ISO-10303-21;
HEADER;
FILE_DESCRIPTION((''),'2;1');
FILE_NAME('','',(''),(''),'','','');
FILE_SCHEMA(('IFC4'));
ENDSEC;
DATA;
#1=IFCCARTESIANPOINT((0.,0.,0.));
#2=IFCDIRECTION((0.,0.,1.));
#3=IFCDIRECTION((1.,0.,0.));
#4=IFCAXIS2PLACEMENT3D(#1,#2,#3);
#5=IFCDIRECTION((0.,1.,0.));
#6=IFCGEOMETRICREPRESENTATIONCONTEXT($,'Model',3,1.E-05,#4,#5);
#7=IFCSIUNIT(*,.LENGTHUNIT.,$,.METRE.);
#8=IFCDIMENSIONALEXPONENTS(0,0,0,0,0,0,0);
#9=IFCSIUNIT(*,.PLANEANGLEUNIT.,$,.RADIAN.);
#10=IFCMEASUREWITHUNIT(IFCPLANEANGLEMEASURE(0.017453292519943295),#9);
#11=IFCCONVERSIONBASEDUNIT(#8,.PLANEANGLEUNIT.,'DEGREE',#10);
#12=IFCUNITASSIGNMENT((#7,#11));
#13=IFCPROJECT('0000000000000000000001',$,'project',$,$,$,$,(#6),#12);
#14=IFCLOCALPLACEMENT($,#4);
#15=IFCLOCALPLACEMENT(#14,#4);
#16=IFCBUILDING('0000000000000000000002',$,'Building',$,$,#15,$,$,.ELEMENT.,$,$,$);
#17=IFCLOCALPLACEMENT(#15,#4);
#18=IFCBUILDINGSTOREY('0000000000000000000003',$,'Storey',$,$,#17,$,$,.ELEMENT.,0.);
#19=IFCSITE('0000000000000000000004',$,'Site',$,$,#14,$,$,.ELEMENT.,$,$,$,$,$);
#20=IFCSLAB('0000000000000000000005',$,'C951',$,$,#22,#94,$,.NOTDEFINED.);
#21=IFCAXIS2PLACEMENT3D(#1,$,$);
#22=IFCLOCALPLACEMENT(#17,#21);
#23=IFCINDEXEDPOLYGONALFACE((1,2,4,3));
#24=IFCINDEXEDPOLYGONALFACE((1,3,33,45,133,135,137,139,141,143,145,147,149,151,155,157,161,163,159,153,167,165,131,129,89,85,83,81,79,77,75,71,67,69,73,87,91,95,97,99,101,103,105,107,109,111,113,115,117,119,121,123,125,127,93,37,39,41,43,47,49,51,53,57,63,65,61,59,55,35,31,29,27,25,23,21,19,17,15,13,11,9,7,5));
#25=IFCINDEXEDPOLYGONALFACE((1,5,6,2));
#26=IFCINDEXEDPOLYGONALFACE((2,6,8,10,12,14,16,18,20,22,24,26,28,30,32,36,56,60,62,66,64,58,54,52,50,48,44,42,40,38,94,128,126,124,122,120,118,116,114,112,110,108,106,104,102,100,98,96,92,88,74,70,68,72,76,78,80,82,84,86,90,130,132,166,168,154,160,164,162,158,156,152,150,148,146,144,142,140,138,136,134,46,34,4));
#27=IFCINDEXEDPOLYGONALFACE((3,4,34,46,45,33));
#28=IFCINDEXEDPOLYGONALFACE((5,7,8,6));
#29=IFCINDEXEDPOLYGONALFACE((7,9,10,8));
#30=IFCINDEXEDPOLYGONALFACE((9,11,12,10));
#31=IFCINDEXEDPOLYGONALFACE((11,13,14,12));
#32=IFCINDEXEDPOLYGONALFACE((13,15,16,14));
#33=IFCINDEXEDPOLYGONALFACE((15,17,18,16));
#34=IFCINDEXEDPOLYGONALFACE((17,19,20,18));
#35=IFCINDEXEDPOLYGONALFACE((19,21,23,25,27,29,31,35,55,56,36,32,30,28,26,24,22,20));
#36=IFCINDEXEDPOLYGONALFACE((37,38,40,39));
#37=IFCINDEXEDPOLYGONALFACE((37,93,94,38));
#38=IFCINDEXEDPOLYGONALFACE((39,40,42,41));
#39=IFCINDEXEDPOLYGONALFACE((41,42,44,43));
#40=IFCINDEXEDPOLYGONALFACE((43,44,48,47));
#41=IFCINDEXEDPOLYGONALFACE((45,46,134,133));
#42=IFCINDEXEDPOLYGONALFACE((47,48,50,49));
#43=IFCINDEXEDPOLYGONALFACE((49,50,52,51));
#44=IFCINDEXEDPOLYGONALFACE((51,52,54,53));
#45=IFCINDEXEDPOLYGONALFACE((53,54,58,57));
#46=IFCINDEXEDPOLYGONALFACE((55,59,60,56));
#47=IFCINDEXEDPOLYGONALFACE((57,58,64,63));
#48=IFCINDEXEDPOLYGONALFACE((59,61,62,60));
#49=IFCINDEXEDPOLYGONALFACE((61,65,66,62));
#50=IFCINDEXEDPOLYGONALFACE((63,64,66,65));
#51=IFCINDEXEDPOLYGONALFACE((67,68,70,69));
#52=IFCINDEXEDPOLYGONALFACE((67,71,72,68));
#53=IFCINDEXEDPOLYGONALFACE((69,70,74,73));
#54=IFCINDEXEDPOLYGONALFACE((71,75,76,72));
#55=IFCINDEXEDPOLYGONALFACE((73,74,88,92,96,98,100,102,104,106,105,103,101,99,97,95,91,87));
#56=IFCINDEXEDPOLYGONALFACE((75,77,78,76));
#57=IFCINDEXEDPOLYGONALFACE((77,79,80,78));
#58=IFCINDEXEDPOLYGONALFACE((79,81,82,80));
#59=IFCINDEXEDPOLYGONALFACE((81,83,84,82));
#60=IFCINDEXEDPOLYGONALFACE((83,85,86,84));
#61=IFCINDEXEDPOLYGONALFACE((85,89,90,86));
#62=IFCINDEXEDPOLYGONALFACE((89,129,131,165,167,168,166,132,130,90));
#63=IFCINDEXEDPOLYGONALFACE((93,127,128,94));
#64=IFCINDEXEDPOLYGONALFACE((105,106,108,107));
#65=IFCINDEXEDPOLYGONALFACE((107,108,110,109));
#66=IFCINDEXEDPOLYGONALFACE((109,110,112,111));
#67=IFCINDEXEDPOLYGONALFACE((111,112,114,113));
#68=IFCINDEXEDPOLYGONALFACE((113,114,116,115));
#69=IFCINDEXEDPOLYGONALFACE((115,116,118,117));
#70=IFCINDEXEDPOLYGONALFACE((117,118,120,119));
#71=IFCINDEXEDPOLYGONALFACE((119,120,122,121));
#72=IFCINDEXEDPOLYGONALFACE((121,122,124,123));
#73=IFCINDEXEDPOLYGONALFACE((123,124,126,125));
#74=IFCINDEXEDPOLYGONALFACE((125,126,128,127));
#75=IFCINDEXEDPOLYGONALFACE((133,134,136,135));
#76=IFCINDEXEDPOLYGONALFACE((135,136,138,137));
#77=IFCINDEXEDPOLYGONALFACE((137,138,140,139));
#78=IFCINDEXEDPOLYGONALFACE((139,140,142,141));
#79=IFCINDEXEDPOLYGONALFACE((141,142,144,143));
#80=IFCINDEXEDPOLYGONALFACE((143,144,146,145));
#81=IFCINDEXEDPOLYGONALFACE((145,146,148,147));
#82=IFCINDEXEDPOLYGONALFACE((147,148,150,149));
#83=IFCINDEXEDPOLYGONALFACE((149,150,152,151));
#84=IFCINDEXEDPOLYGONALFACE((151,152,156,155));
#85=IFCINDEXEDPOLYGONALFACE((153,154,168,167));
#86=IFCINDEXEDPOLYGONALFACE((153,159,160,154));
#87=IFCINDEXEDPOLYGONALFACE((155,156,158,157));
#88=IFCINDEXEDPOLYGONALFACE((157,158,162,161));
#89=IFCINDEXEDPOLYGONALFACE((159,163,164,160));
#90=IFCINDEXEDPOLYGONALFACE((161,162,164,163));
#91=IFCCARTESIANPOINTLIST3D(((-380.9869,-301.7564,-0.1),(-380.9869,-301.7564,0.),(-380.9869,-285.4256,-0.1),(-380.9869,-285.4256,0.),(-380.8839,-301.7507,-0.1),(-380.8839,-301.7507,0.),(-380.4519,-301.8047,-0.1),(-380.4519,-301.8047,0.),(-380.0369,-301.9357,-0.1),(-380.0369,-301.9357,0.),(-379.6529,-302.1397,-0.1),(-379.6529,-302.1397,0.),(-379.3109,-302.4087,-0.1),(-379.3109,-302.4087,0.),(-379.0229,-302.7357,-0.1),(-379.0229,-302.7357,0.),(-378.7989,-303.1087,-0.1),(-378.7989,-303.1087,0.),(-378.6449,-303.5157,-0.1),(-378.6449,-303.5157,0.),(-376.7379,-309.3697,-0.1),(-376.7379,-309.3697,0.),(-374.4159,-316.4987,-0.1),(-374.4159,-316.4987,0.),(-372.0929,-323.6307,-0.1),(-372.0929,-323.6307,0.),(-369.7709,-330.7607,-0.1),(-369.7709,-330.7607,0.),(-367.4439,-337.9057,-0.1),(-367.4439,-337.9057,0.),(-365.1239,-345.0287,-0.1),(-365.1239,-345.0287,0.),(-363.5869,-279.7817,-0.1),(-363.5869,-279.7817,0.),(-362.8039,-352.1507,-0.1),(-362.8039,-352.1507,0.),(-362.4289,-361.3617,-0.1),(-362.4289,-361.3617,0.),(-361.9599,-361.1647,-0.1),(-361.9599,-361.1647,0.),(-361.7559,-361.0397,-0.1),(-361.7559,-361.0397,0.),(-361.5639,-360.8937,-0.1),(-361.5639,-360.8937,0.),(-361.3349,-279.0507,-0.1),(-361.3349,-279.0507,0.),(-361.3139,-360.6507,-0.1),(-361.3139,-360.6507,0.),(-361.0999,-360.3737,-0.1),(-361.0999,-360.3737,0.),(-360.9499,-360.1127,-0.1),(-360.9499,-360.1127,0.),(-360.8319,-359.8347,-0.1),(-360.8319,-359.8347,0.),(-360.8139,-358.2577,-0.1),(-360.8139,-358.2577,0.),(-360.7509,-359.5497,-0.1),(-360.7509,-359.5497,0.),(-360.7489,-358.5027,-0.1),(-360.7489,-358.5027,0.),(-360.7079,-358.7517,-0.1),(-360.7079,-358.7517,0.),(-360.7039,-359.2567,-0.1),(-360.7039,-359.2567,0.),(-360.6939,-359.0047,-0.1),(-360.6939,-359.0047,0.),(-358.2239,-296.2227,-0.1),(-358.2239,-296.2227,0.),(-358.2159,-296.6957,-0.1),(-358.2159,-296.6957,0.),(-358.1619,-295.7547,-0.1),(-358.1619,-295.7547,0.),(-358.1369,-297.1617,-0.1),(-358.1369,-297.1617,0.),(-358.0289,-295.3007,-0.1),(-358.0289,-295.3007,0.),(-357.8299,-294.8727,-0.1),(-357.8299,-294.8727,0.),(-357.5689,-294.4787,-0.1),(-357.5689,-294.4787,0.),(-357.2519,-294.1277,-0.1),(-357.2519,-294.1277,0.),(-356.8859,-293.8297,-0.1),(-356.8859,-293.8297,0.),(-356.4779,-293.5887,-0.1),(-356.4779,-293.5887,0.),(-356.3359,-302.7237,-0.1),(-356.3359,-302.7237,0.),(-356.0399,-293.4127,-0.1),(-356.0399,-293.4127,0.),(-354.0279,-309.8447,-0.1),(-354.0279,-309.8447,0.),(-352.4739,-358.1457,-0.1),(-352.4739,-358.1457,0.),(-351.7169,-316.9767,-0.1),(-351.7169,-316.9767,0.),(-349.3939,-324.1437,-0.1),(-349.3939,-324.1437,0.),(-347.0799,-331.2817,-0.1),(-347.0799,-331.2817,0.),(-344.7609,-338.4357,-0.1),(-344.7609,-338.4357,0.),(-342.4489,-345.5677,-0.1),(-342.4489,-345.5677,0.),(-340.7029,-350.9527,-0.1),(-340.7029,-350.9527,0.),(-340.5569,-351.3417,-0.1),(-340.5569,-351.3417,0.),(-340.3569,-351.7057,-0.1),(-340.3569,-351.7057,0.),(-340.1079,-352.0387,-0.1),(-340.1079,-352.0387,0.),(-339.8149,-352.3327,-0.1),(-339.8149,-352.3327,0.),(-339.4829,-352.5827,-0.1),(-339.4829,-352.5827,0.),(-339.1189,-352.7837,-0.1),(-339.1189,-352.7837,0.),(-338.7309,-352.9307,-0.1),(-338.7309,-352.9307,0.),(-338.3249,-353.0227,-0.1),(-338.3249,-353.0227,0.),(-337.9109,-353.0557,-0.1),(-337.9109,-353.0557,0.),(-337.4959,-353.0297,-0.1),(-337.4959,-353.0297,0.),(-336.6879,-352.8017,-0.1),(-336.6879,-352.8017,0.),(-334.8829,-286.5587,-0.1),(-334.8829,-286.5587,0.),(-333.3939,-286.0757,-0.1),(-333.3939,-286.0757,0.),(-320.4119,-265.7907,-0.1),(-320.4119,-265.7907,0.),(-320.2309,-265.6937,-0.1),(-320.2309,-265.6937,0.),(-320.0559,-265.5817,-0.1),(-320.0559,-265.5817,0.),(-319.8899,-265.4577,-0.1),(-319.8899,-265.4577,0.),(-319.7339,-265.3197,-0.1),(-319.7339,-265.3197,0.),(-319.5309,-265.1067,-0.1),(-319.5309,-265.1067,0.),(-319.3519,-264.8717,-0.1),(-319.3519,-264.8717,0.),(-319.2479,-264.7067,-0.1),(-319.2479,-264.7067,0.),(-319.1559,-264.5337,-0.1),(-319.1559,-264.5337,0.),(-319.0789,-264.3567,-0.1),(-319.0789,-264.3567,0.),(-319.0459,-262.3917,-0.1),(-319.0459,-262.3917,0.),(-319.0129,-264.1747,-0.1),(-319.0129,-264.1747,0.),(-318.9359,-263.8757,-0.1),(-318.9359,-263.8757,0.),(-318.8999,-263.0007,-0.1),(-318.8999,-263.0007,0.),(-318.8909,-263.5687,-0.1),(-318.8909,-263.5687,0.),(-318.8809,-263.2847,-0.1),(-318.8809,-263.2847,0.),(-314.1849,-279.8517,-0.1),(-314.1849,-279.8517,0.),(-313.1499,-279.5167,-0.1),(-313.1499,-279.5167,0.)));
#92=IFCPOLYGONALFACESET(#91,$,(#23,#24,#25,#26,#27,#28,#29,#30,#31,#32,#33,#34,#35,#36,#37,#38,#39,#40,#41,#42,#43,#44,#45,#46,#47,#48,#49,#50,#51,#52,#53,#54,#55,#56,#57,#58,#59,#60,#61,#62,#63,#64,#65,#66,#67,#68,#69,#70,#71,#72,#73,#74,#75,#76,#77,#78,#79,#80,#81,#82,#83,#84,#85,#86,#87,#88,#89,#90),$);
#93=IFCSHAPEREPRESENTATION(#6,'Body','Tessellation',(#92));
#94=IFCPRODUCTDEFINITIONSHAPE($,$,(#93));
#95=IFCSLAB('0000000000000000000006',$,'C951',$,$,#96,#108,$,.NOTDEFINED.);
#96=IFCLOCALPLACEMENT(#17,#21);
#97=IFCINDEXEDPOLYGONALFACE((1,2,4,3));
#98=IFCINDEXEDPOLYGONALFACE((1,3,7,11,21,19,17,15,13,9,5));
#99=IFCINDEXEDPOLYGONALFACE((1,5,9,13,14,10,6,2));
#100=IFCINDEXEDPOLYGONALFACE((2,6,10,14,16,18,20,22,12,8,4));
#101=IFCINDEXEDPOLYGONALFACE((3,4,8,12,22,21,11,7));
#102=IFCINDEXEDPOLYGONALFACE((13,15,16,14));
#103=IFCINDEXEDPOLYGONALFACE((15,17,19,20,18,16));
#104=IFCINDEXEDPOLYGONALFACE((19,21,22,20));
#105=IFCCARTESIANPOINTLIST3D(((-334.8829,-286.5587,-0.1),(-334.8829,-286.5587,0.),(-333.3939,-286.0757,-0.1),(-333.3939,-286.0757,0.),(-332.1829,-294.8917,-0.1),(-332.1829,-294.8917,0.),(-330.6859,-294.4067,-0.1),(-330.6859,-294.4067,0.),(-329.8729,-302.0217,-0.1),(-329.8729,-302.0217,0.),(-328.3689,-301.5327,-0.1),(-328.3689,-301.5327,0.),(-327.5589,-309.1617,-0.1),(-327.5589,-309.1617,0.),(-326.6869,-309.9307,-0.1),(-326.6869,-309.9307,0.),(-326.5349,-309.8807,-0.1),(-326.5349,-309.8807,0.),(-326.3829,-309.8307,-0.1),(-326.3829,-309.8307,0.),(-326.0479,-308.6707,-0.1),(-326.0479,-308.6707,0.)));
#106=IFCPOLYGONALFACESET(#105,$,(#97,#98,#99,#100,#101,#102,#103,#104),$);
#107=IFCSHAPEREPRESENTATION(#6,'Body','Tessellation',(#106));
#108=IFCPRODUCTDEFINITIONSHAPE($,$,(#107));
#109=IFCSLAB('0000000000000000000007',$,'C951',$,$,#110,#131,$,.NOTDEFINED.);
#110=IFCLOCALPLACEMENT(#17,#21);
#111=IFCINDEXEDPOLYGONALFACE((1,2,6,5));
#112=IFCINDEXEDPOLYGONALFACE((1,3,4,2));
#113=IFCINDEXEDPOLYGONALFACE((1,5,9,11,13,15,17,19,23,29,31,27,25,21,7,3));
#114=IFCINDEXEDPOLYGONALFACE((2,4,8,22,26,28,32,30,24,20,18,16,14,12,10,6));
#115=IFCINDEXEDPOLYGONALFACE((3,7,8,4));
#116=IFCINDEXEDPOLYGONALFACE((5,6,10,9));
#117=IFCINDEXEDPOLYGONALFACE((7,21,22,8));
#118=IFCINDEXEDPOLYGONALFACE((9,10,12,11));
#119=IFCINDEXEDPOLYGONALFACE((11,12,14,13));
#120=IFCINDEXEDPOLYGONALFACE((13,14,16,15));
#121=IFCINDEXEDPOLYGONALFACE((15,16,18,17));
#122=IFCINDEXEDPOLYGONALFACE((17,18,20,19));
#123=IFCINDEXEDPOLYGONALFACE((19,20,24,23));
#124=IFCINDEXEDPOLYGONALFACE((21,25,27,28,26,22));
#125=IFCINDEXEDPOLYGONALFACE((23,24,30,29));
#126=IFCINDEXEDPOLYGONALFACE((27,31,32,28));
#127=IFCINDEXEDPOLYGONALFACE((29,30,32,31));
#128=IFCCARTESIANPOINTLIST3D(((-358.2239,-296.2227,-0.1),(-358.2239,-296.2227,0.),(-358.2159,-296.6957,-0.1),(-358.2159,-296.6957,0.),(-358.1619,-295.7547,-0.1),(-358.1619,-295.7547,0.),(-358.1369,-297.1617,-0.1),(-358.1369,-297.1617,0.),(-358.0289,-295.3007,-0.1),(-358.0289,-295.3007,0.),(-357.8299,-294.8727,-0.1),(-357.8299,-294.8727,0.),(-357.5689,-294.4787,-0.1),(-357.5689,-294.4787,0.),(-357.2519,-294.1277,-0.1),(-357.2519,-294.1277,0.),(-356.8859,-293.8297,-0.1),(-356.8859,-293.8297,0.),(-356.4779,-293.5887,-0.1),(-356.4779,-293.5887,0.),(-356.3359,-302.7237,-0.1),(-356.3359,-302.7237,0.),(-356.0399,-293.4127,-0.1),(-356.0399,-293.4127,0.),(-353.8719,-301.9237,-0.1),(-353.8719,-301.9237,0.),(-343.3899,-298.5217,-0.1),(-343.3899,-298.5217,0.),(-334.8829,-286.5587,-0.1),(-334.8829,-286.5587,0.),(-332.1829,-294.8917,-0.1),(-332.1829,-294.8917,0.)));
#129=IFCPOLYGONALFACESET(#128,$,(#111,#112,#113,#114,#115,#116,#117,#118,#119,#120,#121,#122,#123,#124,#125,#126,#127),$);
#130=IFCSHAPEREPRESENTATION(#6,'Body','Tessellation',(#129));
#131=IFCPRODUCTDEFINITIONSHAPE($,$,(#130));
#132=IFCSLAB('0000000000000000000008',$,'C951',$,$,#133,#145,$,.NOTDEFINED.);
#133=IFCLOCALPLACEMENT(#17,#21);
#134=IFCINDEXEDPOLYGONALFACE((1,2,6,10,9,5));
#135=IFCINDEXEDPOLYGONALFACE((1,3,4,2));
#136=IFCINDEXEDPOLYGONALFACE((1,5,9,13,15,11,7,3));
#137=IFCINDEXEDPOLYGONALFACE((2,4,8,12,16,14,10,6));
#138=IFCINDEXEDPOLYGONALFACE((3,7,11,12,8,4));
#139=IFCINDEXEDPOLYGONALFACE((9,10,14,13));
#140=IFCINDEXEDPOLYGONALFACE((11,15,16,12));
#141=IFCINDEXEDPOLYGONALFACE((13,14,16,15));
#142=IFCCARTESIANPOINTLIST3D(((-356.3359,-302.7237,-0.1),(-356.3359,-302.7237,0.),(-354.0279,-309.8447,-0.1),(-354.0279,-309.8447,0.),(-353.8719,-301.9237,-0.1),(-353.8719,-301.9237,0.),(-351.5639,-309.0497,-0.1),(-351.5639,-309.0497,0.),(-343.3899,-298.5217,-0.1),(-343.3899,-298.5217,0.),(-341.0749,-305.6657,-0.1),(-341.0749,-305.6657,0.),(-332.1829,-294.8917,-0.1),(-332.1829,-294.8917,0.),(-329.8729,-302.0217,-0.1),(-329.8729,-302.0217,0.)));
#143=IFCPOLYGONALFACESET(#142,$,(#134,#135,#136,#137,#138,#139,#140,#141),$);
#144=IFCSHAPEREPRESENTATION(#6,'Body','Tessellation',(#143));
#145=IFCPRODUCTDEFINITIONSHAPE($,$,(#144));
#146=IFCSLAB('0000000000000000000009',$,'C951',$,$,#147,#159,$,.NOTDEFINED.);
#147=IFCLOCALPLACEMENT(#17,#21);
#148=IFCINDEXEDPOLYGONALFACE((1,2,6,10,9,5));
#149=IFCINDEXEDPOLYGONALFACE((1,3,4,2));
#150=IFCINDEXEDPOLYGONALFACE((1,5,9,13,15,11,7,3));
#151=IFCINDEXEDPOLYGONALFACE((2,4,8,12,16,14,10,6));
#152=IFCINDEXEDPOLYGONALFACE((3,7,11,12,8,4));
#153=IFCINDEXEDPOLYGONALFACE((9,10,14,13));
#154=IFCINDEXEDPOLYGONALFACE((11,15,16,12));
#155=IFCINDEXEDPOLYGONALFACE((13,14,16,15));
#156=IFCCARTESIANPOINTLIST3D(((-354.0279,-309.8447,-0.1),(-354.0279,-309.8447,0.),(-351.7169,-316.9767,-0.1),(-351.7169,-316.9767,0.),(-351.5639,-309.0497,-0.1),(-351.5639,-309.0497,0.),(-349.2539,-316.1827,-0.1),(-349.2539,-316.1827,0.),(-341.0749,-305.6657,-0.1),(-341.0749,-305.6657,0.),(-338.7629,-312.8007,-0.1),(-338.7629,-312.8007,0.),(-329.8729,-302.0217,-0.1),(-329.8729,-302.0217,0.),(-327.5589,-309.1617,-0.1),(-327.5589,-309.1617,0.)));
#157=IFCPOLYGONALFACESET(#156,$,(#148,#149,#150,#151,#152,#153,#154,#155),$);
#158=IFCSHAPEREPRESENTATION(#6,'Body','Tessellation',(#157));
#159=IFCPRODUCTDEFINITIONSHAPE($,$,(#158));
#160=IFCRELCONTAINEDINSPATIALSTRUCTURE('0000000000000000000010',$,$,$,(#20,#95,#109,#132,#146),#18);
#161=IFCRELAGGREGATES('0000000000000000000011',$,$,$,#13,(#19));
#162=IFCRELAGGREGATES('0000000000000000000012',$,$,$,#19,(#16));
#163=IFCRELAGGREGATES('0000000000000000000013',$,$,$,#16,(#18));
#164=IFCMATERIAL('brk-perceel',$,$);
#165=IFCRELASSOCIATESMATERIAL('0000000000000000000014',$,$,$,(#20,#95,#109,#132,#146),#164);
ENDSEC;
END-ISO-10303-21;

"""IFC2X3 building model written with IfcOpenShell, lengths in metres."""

from ifc_helpers import new_model, entity, si_unit, converted_unit, direction, frame, origin_with_axes, place, context, project, spatial, polyline, outline, extrude, material, element, save


model = new_model("IFC2X3")

# Units and contexts
model_context = context("Model", 3, precision=1e-05, world=origin_with_axes(), true_north=direction((0.0, 1.0, 0.0)))
ifc_project = project(units=[si_unit("LENGTHUNIT", "METRE"), converted_unit("PLANEANGLEUNIT", "DEGREE", entity("IfcPlaneAngleMeasure", 0.017453292519943295), si_unit("PLANEANGLEUNIT", "RADIAN"), dimensions=[0, 0, 0, 0, 0, 0, 0])], contexts=[model_context])

# Site, building, storey
site_placement = place(None, origin_with_axes())
site = spatial("IfcSite", under=ifc_project, at=site_placement, Name="Site", CompositionType="ELEMENT")
building_placement = place(site_placement, origin_with_axes())
building = spatial("IfcBuilding", under=site, at=building_placement, Name="Building", CompositionType="ELEMENT")
storey_placement = place(building_placement, origin_with_axes())
storey = spatial("IfcBuildingStorey", under=building, at=storey_placement, Name="Storey", CompositionType="ELEMENT", Elevation=0.0)

# Slabs
ifc_material = material(Name="brk-perceel")
slab_1_placement = place(storey_placement, frame((0.0, 0.0, -0.1), z_axis=(0.0, 0.0, 1.0), x_axis=(1.0, 0.0, 0.0)))
element("IfcSlab", 1, at=slab_1_placement, inside=storey, material=ifc_material, Name="C951", PredefinedType="NOTDEFINED", context=model_context, shape_type="SweptSolid", body=[
    extrude(outline(polyline([(-363.5869, -279.7817), (-361.3349, -279.0507), (-320.4119, -265.7907), (-320.2309, -265.6937), (-320.0559, -265.5817), (-319.8899, -265.4577), (-319.7339, -265.3197), (-319.5309, -265.1067), (-319.3519, -264.8717), (-319.2479, -264.7067), (-319.1559, -264.5337), (-319.0789, -264.3567), (-319.0129, -264.1747), (-318.9359, -263.8757), (-318.8909, -263.5687), (-318.8809, -263.2847), (-318.8999, -263.0007), (-319.0459, -262.3917), (-313.1499, -279.5167), (-314.1849, -279.8517), (-333.3939, -286.0757), (-334.8829, -286.5587), (-356.0399, -293.4127), (-356.4779, -293.5887), (-356.8859, -293.8297), (-357.2519, -294.1277), (-357.5689, -294.4787), (-357.8299, -294.8727), (-358.0289, -295.3007), (-358.1619, -295.7547), (-358.2239, -296.2227), (-358.2159, -296.6957), (-358.1369, -297.1617), (-356.3359, -302.7237), (-354.0279, -309.8447), (-351.7169, -316.9767), (-349.3939, -324.1437), (-347.0799, -331.2817), (-344.7609, -338.4357), (-342.4489, -345.5677), (-340.7029, -350.9527), (-340.5569, -351.3417), (-340.3569, -351.7057), (-340.1079, -352.0387), (-339.8149, -352.3327), (-339.4829, -352.5827), (-339.1189, -352.7837), (-338.7309, -352.9307), (-338.3249, -353.0227), (-337.9109, -353.0557), (-337.4959, -353.0297), (-336.6879, -352.8017), (-352.4739, -358.1457), (-362.4289, -361.3617), (-361.9599, -361.1647), (-361.7559, -361.0397), (-361.5639, -360.8937), (-361.3139, -360.6507), (-361.0999, -360.3737), (-360.9499, -360.1127), (-360.8319, -359.8347), (-360.7509, -359.5497), (-360.7039, -359.2567), (-360.6939, -359.0047), (-360.7079, -358.7517), (-360.7489, -358.5027), (-360.8139, -358.2577), (-362.8039, -352.1507), (-365.1239, -345.0287), (-367.4439, -337.9057), (-369.7709, -330.7607), (-372.0929, -323.6307), (-374.4159, -316.4987), (-376.7379, -309.3697), (-378.6449, -303.5157), (-378.7989, -303.1087), (-379.0229, -302.7357), (-379.3109, -302.4087), (-379.6529, -302.1397), (-380.0369, -301.9357), (-380.4519, -301.8047), (-380.8839, -301.7507), (-380.9869, -301.7564), (-380.9869, -285.4256), (-363.5869, -279.7817)])), origin_with_axes(), (0.0, 0.0, 1.0), 0.1),
])
slab_2_placement = place(storey_placement, frame((0.0, 0.0, -0.1), z_axis=(0.0, 0.0, 1.0), x_axis=(1.0, 0.0, 0.0)))
element("IfcSlab", 2, at=slab_2_placement, inside=storey, material=ifc_material, Name="C951", PredefinedType="NOTDEFINED", context=model_context, shape_type="SweptSolid", body=[
    extrude(outline(polyline([(-330.6859, -294.4067), (-328.3689, -301.5327), (-326.0479, -308.6707), (-326.3829, -309.8307), (-326.5349, -309.8807), (-326.6869, -309.9307), (-327.5589, -309.1617), (-329.8729, -302.0217), (-332.1829, -294.8917), (-334.8829, -286.5587), (-333.3939, -286.0757), (-330.6859, -294.4067)])), origin_with_axes(), (0.0, 0.0, 1.0), 0.1),
])
slab_3_placement = place(storey_placement, frame((0.0, 0.0, -0.1), z_axis=(0.0, 0.0, 1.0), x_axis=(1.0, 0.0, 0.0)))
element("IfcSlab", 3, at=slab_3_placement, inside=storey, material=ifc_material, Name="C951", PredefinedType="NOTDEFINED", context=model_context, shape_type="SweptSolid", body=[
    extrude(outline(polyline([(-356.3359, -302.7237), (-358.1369, -297.1617), (-358.2159, -296.6957), (-358.2239, -296.2227), (-358.1619, -295.7547), (-358.0289, -295.3007), (-357.8299, -294.8727), (-357.5689, -294.4787), (-357.2519, -294.1277), (-356.8859, -293.8297), (-356.4779, -293.5887), (-356.0399, -293.4127), (-334.8829, -286.5587), (-332.1829, -294.8917), (-343.3899, -298.5217), (-353.8719, -301.9237), (-356.3359, -302.7237)])), origin_with_axes(), (0.0, 0.0, 1.0), 0.1),
])
slab_4_placement = place(storey_placement, frame((0.0, 0.0, -0.1), z_axis=(0.0, 0.0, 1.0), x_axis=(1.0, 0.0, 0.0)))
element("IfcSlab", 4, at=slab_4_placement, inside=storey, material=ifc_material, Name="C951", PredefinedType="NOTDEFINED", context=model_context, shape_type="SweptSolid", body=[
    extrude(outline(polyline([(-354.0279, -309.8447), (-356.3359, -302.7237), (-353.8719, -301.9237), (-343.3899, -298.5217), (-332.1829, -294.8917), (-329.8729, -302.0217), (-341.0749, -305.6657), (-351.5639, -309.0497), (-354.0279, -309.8447)])), origin_with_axes(), (0.0, 0.0, 1.0), 0.1),
])
slab_5_placement = place(storey_placement, frame((0.0, 0.0, -0.1), z_axis=(0.0, 0.0, 1.0), x_axis=(1.0, 0.0, 0.0)))
element("IfcSlab", 5, at=slab_5_placement, inside=storey, material=ifc_material, Name="C951", PredefinedType="NOTDEFINED", context=model_context, shape_type="SweptSolid", body=[
    extrude(outline(polyline([(-351.7169, -316.9767), (-354.0279, -309.8447), (-351.5639, -309.0497), (-341.0749, -305.6657), (-329.8729, -302.0217), (-327.5589, -309.1617), (-338.7629, -312.8007), (-349.2539, -316.1827), (-351.7169, -316.9767)])), origin_with_axes(), (0.0, 0.0, 1.0), 0.1),
])

save(model, "model.ifc")
